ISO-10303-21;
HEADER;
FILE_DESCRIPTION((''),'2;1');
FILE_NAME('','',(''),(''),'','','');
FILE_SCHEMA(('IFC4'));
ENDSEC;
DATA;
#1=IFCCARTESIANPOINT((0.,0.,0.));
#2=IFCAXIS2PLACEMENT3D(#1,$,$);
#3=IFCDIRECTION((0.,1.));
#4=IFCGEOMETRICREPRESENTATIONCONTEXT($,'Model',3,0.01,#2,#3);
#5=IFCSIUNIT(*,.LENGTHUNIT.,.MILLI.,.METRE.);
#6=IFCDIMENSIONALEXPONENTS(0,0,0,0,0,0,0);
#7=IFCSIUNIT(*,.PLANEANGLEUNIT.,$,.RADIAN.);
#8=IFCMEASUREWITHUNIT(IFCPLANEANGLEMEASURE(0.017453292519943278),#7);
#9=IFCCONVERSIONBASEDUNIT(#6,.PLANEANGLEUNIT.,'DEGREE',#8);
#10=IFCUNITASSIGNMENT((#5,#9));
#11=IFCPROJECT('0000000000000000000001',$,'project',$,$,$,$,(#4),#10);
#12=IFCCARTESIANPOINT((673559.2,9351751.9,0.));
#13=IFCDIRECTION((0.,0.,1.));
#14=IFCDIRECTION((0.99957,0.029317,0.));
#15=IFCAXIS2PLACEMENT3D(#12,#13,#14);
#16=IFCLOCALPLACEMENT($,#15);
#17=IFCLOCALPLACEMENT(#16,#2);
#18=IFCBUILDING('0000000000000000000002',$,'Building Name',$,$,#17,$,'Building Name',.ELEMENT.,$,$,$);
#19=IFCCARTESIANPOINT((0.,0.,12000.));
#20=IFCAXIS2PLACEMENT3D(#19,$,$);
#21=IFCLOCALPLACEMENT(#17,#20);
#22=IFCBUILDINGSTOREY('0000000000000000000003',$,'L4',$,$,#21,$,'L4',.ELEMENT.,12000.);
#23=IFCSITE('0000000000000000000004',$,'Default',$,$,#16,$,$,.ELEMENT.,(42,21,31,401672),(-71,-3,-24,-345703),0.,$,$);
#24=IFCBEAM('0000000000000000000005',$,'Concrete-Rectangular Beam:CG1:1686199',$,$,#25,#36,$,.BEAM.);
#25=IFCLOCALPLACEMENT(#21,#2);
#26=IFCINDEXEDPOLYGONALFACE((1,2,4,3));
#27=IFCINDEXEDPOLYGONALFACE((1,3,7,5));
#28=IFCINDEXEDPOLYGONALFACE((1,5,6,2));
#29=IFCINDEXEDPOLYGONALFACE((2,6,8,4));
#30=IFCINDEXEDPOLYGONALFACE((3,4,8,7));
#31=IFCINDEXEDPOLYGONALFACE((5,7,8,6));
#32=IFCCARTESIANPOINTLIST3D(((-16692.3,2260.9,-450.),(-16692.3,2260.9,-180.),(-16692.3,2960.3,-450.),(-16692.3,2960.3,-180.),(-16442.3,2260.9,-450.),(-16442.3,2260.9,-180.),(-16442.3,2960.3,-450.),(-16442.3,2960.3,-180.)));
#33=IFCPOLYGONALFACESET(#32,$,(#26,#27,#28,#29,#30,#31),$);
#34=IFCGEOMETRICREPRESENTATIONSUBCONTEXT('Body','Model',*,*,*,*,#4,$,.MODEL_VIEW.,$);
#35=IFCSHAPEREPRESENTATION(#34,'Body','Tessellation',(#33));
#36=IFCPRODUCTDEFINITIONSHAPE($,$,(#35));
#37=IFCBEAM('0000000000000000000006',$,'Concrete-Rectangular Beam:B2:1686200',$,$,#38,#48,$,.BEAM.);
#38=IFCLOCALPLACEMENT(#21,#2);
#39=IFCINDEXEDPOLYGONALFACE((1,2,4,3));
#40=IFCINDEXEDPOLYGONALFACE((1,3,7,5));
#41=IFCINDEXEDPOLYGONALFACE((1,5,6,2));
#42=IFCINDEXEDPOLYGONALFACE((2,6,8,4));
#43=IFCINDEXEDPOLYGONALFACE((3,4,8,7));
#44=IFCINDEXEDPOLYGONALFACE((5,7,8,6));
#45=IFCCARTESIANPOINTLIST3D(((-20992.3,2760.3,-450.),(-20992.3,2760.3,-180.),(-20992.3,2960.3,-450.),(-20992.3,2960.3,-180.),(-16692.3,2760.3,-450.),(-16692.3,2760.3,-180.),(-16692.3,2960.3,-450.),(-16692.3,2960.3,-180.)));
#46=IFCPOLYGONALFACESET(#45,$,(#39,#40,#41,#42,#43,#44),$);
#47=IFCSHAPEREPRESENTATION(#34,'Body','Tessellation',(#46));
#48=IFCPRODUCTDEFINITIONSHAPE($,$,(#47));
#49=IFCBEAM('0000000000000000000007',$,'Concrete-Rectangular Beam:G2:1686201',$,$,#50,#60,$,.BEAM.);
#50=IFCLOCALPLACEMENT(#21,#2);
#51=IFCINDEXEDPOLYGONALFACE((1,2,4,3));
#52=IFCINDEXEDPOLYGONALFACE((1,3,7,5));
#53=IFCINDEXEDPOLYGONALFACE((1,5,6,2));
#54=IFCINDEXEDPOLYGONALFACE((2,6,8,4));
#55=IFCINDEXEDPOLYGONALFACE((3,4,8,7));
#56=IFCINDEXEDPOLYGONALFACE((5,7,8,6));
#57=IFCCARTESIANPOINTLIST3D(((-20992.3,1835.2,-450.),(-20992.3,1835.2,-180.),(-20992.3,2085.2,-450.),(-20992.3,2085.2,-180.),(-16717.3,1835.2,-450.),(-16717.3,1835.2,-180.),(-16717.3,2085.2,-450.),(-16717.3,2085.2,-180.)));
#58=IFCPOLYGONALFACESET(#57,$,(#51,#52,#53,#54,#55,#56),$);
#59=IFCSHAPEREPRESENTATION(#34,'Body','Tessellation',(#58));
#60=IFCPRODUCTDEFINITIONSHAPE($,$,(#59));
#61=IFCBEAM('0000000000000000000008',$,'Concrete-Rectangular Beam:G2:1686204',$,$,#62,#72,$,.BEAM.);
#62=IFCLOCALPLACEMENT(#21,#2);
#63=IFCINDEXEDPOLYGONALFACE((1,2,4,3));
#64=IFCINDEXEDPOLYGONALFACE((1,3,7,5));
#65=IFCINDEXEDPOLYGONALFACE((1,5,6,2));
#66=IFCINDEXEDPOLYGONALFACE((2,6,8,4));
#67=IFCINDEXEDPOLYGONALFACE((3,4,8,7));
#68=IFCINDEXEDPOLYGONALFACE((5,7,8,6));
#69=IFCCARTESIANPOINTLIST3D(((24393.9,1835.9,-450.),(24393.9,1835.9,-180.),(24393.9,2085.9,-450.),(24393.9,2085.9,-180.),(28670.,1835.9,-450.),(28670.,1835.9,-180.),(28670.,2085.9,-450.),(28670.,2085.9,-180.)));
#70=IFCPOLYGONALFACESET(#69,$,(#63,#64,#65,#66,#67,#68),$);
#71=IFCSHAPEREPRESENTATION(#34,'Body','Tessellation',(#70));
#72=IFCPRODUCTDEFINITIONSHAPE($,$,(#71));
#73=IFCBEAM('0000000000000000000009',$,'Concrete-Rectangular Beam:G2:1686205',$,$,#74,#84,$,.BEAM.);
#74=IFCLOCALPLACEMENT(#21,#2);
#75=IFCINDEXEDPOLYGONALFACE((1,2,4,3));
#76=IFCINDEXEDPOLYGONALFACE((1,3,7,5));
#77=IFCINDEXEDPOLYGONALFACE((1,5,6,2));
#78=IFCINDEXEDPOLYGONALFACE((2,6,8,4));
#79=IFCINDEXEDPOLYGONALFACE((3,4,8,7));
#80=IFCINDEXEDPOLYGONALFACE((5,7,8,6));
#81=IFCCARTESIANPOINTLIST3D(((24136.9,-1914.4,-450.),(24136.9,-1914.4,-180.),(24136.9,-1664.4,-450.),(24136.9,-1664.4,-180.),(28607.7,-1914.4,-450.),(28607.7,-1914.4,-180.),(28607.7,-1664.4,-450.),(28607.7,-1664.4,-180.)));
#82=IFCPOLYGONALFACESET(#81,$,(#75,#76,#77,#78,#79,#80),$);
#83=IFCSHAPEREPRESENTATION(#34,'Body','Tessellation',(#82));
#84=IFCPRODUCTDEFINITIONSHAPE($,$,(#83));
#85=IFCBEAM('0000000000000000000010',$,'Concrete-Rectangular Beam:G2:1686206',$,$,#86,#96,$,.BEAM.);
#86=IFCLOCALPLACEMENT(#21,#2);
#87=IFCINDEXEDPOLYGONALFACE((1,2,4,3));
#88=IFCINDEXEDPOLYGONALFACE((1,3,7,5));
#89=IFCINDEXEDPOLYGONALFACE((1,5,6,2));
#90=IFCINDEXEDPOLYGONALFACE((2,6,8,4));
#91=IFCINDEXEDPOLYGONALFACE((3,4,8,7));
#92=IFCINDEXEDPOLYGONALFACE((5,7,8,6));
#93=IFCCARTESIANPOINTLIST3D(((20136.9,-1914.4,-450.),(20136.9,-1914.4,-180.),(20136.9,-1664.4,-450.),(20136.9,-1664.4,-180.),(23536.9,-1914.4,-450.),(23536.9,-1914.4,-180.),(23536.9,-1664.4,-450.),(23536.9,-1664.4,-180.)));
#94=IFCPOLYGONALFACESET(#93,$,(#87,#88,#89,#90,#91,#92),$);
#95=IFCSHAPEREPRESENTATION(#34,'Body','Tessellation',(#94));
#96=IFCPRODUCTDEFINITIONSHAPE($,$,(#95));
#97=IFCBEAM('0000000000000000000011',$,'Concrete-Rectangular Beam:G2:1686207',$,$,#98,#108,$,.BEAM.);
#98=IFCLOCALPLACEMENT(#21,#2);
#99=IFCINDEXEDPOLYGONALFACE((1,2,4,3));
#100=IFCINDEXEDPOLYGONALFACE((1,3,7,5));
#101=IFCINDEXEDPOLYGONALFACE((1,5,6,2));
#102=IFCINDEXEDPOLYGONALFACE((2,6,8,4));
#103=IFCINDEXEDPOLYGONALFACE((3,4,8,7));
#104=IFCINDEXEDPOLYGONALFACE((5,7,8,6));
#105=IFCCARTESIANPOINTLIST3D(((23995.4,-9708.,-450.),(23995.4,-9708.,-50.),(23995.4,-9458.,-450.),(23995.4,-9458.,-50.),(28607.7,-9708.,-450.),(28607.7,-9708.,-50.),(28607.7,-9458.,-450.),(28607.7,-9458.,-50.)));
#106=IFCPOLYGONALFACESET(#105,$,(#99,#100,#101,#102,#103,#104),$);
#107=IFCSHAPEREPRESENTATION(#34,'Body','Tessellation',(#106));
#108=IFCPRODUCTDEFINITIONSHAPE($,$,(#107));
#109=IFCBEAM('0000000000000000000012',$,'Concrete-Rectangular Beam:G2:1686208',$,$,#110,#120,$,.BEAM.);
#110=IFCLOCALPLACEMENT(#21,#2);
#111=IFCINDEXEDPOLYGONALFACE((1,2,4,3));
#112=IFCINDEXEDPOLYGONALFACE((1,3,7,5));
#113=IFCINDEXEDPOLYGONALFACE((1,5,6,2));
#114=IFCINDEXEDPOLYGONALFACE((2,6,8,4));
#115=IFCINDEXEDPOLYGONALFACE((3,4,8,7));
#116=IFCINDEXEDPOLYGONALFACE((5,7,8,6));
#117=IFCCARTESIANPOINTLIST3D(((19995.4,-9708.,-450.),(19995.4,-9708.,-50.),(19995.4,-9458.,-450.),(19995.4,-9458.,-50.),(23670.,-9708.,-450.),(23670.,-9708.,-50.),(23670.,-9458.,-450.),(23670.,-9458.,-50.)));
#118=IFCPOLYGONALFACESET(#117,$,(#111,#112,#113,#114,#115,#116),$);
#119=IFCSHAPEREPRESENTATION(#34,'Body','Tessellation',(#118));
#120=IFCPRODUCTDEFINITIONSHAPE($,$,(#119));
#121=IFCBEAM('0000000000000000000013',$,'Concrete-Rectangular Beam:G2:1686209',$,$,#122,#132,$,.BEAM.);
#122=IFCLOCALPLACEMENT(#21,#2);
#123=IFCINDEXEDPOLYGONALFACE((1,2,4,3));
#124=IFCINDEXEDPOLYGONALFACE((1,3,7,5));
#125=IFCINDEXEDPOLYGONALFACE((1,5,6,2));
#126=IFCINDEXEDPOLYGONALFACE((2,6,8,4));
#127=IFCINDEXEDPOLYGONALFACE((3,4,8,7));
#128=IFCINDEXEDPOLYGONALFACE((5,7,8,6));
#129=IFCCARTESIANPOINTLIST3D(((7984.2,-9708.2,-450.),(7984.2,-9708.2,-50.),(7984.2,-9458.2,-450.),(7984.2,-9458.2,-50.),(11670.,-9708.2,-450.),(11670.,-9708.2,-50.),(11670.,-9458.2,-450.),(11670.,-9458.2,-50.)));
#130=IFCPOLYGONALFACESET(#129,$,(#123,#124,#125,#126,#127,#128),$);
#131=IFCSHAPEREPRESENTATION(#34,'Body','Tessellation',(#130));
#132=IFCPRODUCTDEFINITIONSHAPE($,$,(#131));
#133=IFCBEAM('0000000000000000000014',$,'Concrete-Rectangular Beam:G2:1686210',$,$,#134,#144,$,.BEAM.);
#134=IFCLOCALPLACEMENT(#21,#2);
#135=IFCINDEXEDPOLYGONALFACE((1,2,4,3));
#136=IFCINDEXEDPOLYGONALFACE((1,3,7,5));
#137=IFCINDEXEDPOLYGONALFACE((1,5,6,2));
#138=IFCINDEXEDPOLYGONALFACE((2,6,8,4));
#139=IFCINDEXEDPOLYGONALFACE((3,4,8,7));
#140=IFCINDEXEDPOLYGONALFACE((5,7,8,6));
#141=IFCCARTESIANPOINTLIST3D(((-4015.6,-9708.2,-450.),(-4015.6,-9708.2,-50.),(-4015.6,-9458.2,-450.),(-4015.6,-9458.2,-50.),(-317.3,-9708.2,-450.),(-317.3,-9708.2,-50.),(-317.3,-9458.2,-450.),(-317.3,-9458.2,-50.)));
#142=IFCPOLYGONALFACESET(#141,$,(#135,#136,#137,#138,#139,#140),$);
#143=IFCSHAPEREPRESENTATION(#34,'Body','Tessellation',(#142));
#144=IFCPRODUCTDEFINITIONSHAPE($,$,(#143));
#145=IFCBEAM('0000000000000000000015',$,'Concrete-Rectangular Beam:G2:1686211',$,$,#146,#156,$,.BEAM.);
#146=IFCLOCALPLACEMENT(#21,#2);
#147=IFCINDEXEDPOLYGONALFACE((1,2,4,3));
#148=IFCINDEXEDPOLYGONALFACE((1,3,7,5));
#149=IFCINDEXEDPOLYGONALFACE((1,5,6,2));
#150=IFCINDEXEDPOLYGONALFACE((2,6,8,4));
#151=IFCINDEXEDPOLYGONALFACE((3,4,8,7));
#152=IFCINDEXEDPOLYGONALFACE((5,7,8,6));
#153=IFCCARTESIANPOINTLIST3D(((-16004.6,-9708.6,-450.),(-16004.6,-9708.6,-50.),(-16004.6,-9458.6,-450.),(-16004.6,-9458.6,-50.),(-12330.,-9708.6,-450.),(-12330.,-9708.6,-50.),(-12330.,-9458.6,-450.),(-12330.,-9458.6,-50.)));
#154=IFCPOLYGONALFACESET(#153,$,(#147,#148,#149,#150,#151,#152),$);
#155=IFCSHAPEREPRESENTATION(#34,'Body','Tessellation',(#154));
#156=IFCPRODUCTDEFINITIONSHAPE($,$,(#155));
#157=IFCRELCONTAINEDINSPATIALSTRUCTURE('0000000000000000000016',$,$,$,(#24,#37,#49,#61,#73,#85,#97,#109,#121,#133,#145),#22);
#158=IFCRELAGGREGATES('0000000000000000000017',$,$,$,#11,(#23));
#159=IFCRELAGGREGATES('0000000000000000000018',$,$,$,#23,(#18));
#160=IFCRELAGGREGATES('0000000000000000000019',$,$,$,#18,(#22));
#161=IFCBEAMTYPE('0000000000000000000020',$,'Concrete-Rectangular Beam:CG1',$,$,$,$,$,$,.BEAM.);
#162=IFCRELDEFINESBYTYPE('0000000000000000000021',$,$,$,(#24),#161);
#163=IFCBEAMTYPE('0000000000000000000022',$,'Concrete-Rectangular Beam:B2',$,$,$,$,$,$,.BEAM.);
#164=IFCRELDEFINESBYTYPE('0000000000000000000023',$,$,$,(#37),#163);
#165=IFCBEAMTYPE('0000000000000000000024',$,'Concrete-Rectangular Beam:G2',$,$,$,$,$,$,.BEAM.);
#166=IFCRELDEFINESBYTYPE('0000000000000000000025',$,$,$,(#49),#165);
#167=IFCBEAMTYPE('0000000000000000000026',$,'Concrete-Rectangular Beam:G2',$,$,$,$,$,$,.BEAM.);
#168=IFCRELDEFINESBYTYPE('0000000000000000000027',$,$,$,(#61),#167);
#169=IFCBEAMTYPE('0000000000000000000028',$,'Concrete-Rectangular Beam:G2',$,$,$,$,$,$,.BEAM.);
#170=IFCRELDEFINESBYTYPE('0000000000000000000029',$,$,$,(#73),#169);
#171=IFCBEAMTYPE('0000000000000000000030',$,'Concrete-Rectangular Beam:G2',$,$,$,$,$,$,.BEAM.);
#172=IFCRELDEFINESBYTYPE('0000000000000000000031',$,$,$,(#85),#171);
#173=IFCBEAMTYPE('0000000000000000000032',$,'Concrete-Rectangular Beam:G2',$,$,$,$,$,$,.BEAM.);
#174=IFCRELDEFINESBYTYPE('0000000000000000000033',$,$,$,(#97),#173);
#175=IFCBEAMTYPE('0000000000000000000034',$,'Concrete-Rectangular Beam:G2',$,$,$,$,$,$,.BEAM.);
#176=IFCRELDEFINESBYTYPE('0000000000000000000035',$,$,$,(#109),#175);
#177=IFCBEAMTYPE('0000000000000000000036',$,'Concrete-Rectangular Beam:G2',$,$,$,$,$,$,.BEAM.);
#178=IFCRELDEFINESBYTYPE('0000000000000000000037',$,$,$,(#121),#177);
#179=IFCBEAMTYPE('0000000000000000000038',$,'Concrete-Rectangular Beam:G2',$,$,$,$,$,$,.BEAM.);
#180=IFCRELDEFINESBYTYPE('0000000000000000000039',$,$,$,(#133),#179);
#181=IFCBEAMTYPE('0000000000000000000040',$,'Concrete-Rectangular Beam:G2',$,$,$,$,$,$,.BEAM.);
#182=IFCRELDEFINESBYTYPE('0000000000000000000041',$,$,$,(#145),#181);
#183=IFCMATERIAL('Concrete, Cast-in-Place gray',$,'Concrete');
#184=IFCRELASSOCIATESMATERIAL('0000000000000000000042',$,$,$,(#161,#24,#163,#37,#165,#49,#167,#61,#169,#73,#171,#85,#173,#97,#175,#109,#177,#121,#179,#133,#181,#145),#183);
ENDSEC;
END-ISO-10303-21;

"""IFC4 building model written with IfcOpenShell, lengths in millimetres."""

from ifc_helpers import new_model, entity, si_unit, converted_unit, direction, frame, origin, place, context, subcontext, project, spatial, indexed_curve, outline, extrude, source, transform, mapped, material, type_object, type_shapes, element, save


model = new_model("IFC4")

# Units and contexts
model_context = context("Model", 3, precision=0.01, world=origin(), true_north=direction((0.0, 1.0)))
body_context = subcontext(model_context, "Body", "Model", "MODEL_VIEW")
ifc_project = project(units=[si_unit("LENGTHUNIT", "METRE", prefix="MILLI"), converted_unit("PLANEANGLEUNIT", "DEGREE", entity("IfcPlaneAngleMeasure", 0.017453292519943278), si_unit("PLANEANGLEUNIT", "RADIAN"), dimensions=[0, 0, 0, 0, 0, 0, 0])], contexts=[model_context])

# Site, building, storey
site_placement = place(None, frame((673559.2, 9351751.9, 0.0), z_axis=(0.0, 0.0, 1.0), x_axis=(0.99957, 0.029317, 0.0)))
site = spatial("IfcSite", under=ifc_project, at=site_placement, Name="Default", CompositionType="ELEMENT", RefLatitude=(42, 21, 31, 401672), RefLongitude=(-71, -3, -24, -345703), RefElevation=0.0)
building_placement = place(site_placement, origin())
building = spatial("IfcBuilding", under=site, at=building_placement, Name="Building Name", LongName="Building Name", CompositionType="ELEMENT")
storey_placement = place(building_placement, frame((0.0, 0.0, 12000.0)))
storey = spatial("IfcBuildingStorey", under=building, at=storey_placement, Name="L4", LongName="L4", CompositionType="ELEMENT", Elevation=12000.0)

# Beams
ifc_material = material(Name="Concrete, Cast-in-Place gray", Category="Concrete")
beam_type_1 = type_object("IfcBeamType", Name="Concrete-Rectangular Beam:CG1", PredefinedType="BEAM", material=ifc_material)
shared_shape_1 = source(origin(), body_context, "Body", "SweptSolid", [
    extrude(outline(indexed_curve([(-125.0, -135.0), (125.0, -135.0), (125.0, 135.0), (-125.0, 135.0), (-125.0, -135.0)], self_intersect=False)), frame((-16567.3, 2260.9, 11685.0), z_axis=(0.0, 1.0, 0.0), x_axis=(-1.0, 0.0, 0.0)), (0.0, 0.0, 1.0), 699.4),
])
type_shapes(beam_type_1, [shared_shape_1])
beam_1_placement = place(storey_placement, frame((0.0, 0.0, -12000.0)))
element("IfcBeam", 1, at=beam_1_placement, inside=storey, type_object=beam_type_1, material=ifc_material, Name="Concrete-Rectangular Beam:CG1:1686199", PredefinedType="BEAM", context=body_context, shape_type="MappedRepresentation", body=[
    mapped(shared_shape_1, transform((0.0, 0.0, 0.0), scale=1.0)),
])
beam_type_2 = type_object("IfcBeamType", Name="Concrete-Rectangular Beam:B2", PredefinedType="BEAM", material=ifc_material)
shared_shape_2 = source(origin(), body_context, "Body", "SweptSolid", [
    extrude(outline(indexed_curve([(-135.0, -100.0), (135.0, -100.0), (135.0, 100.0), (-135.0, 100.0), (-135.0, -100.0)], self_intersect=False)), frame((-20992.3, 2860.3, 11685.0), z_axis=(1.0, 0.0, 0.0), x_axis=(0.0, 0.0, -1.0)), (0.0, 0.0, 1.0), 4300.0),
])
type_shapes(beam_type_2, [shared_shape_2])
beam_2_placement = place(storey_placement, frame((0.0, 0.0, -12000.0)))
element("IfcBeam", 2, at=beam_2_placement, inside=storey, type_object=beam_type_2, material=ifc_material, Name="Concrete-Rectangular Beam:B2:1686200", PredefinedType="BEAM", context=body_context, shape_type="MappedRepresentation", body=[
    mapped(shared_shape_2, transform((0.0, 0.0, 0.0), scale=1.0)),
])
beam_type_3 = type_object("IfcBeamType", Name="Concrete-Rectangular Beam:G2", PredefinedType="BEAM", material=ifc_material)
shared_shape_3 = source(origin(), body_context, "Body", "SweptSolid", [
    extrude(outline(indexed_curve([(-135.0, -125.0), (135.0, -125.0), (135.0, 125.0), (-135.0, 125.0), (-135.0, -125.0)], self_intersect=False)), frame((-20992.3, 1960.2, 11685.0), z_axis=(1.0, 0.0, 0.0), x_axis=(0.0, 0.0, -1.0)), (0.0, 0.0, 1.0), 4275.0),
])
type_shapes(beam_type_3, [shared_shape_3])
beam_3_placement = place(storey_placement, frame((0.0, 0.0, -12000.0)))
element("IfcBeam", 3, at=beam_3_placement, inside=storey, type_object=beam_type_3, material=ifc_material, Name="Concrete-Rectangular Beam:G2:1686201", PredefinedType="BEAM", context=body_context, shape_type="MappedRepresentation", body=[
    mapped(shared_shape_3, transform((0.0, 0.0, 0.0), scale=1.0)),
])
beam_type_4 = type_object("IfcBeamType", Name="Concrete-Rectangular Beam:G2", PredefinedType="BEAM", material=ifc_material)
shared_shape_4 = source(origin(), body_context, "Body", "SweptSolid", [
    extrude(outline(indexed_curve([(-135.0, -125.0), (135.0, -125.0), (135.0, 125.0), (-135.0, 125.0), (-135.0, -125.0)], self_intersect=False)), frame((28670.0, 1960.9, 11685.0), z_axis=(-1.0, 0.0, 0.0), x_axis=(0.0, 0.0, -1.0)), (0.0, 0.0, 1.0), 4276.1),
])
type_shapes(beam_type_4, [shared_shape_4])
beam_4_placement = place(storey_placement, frame((0.0, 0.0, -12000.0)))
element("IfcBeam", 4, at=beam_4_placement, inside=storey, type_object=beam_type_4, material=ifc_material, Name="Concrete-Rectangular Beam:G2:1686204", PredefinedType="BEAM", context=body_context, shape_type="MappedRepresentation", body=[
    mapped(shared_shape_4, transform((0.0, 0.0, 0.0), scale=1.0)),
])
beam_type_5 = type_object("IfcBeamType", Name="Concrete-Rectangular Beam:G2", PredefinedType="BEAM", material=ifc_material)
shared_shape_5 = source(origin(), body_context, "Body", "SweptSolid", [
    extrude(outline(indexed_curve([(-135.0, -125.0), (135.0, -125.0), (135.0, 125.0), (-135.0, 125.0), (-135.0, -125.0)], self_intersect=False)), frame((28607.7, -1789.4, 11685.0), z_axis=(-1.0, 0.0, 0.0), x_axis=(0.0, 0.0, -1.0)), (0.0, 0.0, 1.0), 4470.8),
])
type_shapes(beam_type_5, [shared_shape_5])
beam_5_placement = place(storey_placement, frame((0.0, 0.0, -12000.0)))
element("IfcBeam", 5, at=beam_5_placement, inside=storey, type_object=beam_type_5, material=ifc_material, Name="Concrete-Rectangular Beam:G2:1686205", PredefinedType="BEAM", context=body_context, shape_type="MappedRepresentation", body=[
    mapped(shared_shape_5, transform((0.0, 0.0, 0.0), scale=1.0)),
])
beam_type_6 = type_object("IfcBeamType", Name="Concrete-Rectangular Beam:G2", PredefinedType="BEAM", material=ifc_material)
shared_shape_6 = source(origin(), body_context, "Body", "SweptSolid", [
    extrude(outline(indexed_curve([(-135.0, -125.0), (135.0, -125.0), (135.0, 125.0), (-135.0, 125.0), (-135.0, -125.0)], self_intersect=False)), frame((23536.9, -1789.4, 11685.0), z_axis=(-1.0, 0.0, 0.0), x_axis=(0.0, 0.0, -1.0)), (0.0, 0.0, 1.0), 3400.0),
])
type_shapes(beam_type_6, [shared_shape_6])
beam_6_placement = place(storey_placement, frame((0.0, 0.0, -12000.0)))
element("IfcBeam", 6, at=beam_6_placement, inside=storey, type_object=beam_type_6, material=ifc_material, Name="Concrete-Rectangular Beam:G2:1686206", PredefinedType="BEAM", context=body_context, shape_type="MappedRepresentation", body=[
    mapped(shared_shape_6, transform((0.0, 0.0, 0.0), scale=1.0)),
])
beam_type_7 = type_object("IfcBeamType", Name="Concrete-Rectangular Beam:G2", PredefinedType="BEAM", material=ifc_material)
shared_shape_7 = source(origin(), body_context, "Body", "SweptSolid", [
    extrude(outline(indexed_curve([(-200.0, -125.0), (200.0, -125.0), (200.0, 125.0), (-200.0, 125.0), (-200.0, -125.0)], self_intersect=False)), frame((28607.7, -9583.0, 11750.0), z_axis=(-1.0, 0.0, 0.0), x_axis=(0.0, 0.0, -1.0)), (0.0, 0.0, 1.0), 4612.3),
])
type_shapes(beam_type_7, [shared_shape_7])
beam_7_placement = place(storey_placement, frame((0.0, 0.0, -12000.0)))
element("IfcBeam", 7, at=beam_7_placement, inside=storey, type_object=beam_type_7, material=ifc_material, Name="Concrete-Rectangular Beam:G2:1686207", PredefinedType="BEAM", context=body_context, shape_type="MappedRepresentation", body=[
    mapped(shared_shape_7, transform((0.0, 0.0, 0.0), scale=1.0)),
])
beam_type_8 = type_object("IfcBeamType", Name="Concrete-Rectangular Beam:G2", PredefinedType="BEAM", material=ifc_material)
shared_shape_8 = source(origin(), body_context, "Body", "SweptSolid", [
    extrude(outline(indexed_curve([(-200.0, -125.0), (200.0, -125.0), (200.0, 125.0), (-200.0, 125.0), (-200.0, -125.0)], self_intersect=False)), frame((23670.0, -9583.0, 11750.0), z_axis=(-1.0, 0.0, 0.0), x_axis=(0.0, 0.0, -1.0)), (0.0, 0.0, 1.0), 3674.6),
])
type_shapes(beam_type_8, [shared_shape_8])
beam_8_placement = place(storey_placement, frame((0.0, 0.0, -12000.0)))
element("IfcBeam", 8, at=beam_8_placement, inside=storey, type_object=beam_type_8, material=ifc_material, Name="Concrete-Rectangular Beam:G2:1686208", PredefinedType="BEAM", context=body_context, shape_type="MappedRepresentation", body=[
    mapped(shared_shape_8, transform((0.0, 0.0, 0.0), scale=1.0)),
])
beam_type_9 = type_object("IfcBeamType", Name="Concrete-Rectangular Beam:G2", PredefinedType="BEAM", material=ifc_material)
shared_shape_9 = source(origin(), body_context, "Body", "SweptSolid", [
    extrude(outline(indexed_curve([(-200.0, -125.0), (200.0, -125.0), (200.0, 125.0), (-200.0, 125.0), (-200.0, -125.0)], self_intersect=False)), frame((11670.0, -9583.2, 11750.0), z_axis=(-1.0, 0.0, 0.0), x_axis=(0.0, 0.0, -1.0)), (0.0, 0.0, 1.0), 3685.8),
])
type_shapes(beam_type_9, [shared_shape_9])
beam_9_placement = place(storey_placement, frame((0.0, 0.0, -12000.0)))
element("IfcBeam", 9, at=beam_9_placement, inside=storey, type_object=beam_type_9, material=ifc_material, Name="Concrete-Rectangular Beam:G2:1686209", PredefinedType="BEAM", context=body_context, shape_type="MappedRepresentation", body=[
    mapped(shared_shape_9, transform((0.0, 0.0, 0.0), scale=1.0)),
])
beam_type_10 = type_object("IfcBeamType", Name="Concrete-Rectangular Beam:G2", PredefinedType="BEAM", material=ifc_material)
shared_shape_10 = source(origin(), body_context, "Body", "SweptSolid", [
    extrude(outline(indexed_curve([(-200.0, -125.0), (200.0, -125.0), (200.0, 125.0), (-200.0, 125.0), (-200.0, -125.0)], self_intersect=False)), frame((-317.3, -9583.2, 11750.0), z_axis=(-1.0, 0.0, 0.0), x_axis=(0.0, 0.0, -1.0)), (0.0, 0.0, 1.0), 3698.2),
])
type_shapes(beam_type_10, [shared_shape_10])
beam_10_placement = place(storey_placement, frame((0.0, 0.0, -12000.0)))
element("IfcBeam", 10, at=beam_10_placement, inside=storey, type_object=beam_type_10, material=ifc_material, Name="Concrete-Rectangular Beam:G2:1686210", PredefinedType="BEAM", context=body_context, shape_type="MappedRepresentation", body=[
    mapped(shared_shape_10, transform((0.0, 0.0, 0.0), scale=1.0)),
])
beam_type_11 = type_object("IfcBeamType", Name="Concrete-Rectangular Beam:G2", PredefinedType="BEAM", material=ifc_material)
shared_shape_11 = source(origin(), body_context, "Body", "SweptSolid", [
    extrude(outline(indexed_curve([(-200.0, -125.0), (200.0, -125.0), (200.0, 125.0), (-200.0, 125.0), (-200.0, -125.0)], self_intersect=False)), frame((-12330.0, -9583.6, 11750.0), z_axis=(-1.0, 0.0, 0.0), x_axis=(0.0, 0.0, -1.0)), (0.0, 0.0, 1.0), 3674.6),
])
type_shapes(beam_type_11, [shared_shape_11])
beam_11_placement = place(storey_placement, frame((0.0, 0.0, -12000.0)))
element("IfcBeam", 11, at=beam_11_placement, inside=storey, type_object=beam_type_11, material=ifc_material, Name="Concrete-Rectangular Beam:G2:1686211", PredefinedType="BEAM", context=body_context, shape_type="MappedRepresentation", body=[
    mapped(shared_shape_11, transform((0.0, 0.0, 0.0), scale=1.0)),
])

save(model, "model.ifc")
